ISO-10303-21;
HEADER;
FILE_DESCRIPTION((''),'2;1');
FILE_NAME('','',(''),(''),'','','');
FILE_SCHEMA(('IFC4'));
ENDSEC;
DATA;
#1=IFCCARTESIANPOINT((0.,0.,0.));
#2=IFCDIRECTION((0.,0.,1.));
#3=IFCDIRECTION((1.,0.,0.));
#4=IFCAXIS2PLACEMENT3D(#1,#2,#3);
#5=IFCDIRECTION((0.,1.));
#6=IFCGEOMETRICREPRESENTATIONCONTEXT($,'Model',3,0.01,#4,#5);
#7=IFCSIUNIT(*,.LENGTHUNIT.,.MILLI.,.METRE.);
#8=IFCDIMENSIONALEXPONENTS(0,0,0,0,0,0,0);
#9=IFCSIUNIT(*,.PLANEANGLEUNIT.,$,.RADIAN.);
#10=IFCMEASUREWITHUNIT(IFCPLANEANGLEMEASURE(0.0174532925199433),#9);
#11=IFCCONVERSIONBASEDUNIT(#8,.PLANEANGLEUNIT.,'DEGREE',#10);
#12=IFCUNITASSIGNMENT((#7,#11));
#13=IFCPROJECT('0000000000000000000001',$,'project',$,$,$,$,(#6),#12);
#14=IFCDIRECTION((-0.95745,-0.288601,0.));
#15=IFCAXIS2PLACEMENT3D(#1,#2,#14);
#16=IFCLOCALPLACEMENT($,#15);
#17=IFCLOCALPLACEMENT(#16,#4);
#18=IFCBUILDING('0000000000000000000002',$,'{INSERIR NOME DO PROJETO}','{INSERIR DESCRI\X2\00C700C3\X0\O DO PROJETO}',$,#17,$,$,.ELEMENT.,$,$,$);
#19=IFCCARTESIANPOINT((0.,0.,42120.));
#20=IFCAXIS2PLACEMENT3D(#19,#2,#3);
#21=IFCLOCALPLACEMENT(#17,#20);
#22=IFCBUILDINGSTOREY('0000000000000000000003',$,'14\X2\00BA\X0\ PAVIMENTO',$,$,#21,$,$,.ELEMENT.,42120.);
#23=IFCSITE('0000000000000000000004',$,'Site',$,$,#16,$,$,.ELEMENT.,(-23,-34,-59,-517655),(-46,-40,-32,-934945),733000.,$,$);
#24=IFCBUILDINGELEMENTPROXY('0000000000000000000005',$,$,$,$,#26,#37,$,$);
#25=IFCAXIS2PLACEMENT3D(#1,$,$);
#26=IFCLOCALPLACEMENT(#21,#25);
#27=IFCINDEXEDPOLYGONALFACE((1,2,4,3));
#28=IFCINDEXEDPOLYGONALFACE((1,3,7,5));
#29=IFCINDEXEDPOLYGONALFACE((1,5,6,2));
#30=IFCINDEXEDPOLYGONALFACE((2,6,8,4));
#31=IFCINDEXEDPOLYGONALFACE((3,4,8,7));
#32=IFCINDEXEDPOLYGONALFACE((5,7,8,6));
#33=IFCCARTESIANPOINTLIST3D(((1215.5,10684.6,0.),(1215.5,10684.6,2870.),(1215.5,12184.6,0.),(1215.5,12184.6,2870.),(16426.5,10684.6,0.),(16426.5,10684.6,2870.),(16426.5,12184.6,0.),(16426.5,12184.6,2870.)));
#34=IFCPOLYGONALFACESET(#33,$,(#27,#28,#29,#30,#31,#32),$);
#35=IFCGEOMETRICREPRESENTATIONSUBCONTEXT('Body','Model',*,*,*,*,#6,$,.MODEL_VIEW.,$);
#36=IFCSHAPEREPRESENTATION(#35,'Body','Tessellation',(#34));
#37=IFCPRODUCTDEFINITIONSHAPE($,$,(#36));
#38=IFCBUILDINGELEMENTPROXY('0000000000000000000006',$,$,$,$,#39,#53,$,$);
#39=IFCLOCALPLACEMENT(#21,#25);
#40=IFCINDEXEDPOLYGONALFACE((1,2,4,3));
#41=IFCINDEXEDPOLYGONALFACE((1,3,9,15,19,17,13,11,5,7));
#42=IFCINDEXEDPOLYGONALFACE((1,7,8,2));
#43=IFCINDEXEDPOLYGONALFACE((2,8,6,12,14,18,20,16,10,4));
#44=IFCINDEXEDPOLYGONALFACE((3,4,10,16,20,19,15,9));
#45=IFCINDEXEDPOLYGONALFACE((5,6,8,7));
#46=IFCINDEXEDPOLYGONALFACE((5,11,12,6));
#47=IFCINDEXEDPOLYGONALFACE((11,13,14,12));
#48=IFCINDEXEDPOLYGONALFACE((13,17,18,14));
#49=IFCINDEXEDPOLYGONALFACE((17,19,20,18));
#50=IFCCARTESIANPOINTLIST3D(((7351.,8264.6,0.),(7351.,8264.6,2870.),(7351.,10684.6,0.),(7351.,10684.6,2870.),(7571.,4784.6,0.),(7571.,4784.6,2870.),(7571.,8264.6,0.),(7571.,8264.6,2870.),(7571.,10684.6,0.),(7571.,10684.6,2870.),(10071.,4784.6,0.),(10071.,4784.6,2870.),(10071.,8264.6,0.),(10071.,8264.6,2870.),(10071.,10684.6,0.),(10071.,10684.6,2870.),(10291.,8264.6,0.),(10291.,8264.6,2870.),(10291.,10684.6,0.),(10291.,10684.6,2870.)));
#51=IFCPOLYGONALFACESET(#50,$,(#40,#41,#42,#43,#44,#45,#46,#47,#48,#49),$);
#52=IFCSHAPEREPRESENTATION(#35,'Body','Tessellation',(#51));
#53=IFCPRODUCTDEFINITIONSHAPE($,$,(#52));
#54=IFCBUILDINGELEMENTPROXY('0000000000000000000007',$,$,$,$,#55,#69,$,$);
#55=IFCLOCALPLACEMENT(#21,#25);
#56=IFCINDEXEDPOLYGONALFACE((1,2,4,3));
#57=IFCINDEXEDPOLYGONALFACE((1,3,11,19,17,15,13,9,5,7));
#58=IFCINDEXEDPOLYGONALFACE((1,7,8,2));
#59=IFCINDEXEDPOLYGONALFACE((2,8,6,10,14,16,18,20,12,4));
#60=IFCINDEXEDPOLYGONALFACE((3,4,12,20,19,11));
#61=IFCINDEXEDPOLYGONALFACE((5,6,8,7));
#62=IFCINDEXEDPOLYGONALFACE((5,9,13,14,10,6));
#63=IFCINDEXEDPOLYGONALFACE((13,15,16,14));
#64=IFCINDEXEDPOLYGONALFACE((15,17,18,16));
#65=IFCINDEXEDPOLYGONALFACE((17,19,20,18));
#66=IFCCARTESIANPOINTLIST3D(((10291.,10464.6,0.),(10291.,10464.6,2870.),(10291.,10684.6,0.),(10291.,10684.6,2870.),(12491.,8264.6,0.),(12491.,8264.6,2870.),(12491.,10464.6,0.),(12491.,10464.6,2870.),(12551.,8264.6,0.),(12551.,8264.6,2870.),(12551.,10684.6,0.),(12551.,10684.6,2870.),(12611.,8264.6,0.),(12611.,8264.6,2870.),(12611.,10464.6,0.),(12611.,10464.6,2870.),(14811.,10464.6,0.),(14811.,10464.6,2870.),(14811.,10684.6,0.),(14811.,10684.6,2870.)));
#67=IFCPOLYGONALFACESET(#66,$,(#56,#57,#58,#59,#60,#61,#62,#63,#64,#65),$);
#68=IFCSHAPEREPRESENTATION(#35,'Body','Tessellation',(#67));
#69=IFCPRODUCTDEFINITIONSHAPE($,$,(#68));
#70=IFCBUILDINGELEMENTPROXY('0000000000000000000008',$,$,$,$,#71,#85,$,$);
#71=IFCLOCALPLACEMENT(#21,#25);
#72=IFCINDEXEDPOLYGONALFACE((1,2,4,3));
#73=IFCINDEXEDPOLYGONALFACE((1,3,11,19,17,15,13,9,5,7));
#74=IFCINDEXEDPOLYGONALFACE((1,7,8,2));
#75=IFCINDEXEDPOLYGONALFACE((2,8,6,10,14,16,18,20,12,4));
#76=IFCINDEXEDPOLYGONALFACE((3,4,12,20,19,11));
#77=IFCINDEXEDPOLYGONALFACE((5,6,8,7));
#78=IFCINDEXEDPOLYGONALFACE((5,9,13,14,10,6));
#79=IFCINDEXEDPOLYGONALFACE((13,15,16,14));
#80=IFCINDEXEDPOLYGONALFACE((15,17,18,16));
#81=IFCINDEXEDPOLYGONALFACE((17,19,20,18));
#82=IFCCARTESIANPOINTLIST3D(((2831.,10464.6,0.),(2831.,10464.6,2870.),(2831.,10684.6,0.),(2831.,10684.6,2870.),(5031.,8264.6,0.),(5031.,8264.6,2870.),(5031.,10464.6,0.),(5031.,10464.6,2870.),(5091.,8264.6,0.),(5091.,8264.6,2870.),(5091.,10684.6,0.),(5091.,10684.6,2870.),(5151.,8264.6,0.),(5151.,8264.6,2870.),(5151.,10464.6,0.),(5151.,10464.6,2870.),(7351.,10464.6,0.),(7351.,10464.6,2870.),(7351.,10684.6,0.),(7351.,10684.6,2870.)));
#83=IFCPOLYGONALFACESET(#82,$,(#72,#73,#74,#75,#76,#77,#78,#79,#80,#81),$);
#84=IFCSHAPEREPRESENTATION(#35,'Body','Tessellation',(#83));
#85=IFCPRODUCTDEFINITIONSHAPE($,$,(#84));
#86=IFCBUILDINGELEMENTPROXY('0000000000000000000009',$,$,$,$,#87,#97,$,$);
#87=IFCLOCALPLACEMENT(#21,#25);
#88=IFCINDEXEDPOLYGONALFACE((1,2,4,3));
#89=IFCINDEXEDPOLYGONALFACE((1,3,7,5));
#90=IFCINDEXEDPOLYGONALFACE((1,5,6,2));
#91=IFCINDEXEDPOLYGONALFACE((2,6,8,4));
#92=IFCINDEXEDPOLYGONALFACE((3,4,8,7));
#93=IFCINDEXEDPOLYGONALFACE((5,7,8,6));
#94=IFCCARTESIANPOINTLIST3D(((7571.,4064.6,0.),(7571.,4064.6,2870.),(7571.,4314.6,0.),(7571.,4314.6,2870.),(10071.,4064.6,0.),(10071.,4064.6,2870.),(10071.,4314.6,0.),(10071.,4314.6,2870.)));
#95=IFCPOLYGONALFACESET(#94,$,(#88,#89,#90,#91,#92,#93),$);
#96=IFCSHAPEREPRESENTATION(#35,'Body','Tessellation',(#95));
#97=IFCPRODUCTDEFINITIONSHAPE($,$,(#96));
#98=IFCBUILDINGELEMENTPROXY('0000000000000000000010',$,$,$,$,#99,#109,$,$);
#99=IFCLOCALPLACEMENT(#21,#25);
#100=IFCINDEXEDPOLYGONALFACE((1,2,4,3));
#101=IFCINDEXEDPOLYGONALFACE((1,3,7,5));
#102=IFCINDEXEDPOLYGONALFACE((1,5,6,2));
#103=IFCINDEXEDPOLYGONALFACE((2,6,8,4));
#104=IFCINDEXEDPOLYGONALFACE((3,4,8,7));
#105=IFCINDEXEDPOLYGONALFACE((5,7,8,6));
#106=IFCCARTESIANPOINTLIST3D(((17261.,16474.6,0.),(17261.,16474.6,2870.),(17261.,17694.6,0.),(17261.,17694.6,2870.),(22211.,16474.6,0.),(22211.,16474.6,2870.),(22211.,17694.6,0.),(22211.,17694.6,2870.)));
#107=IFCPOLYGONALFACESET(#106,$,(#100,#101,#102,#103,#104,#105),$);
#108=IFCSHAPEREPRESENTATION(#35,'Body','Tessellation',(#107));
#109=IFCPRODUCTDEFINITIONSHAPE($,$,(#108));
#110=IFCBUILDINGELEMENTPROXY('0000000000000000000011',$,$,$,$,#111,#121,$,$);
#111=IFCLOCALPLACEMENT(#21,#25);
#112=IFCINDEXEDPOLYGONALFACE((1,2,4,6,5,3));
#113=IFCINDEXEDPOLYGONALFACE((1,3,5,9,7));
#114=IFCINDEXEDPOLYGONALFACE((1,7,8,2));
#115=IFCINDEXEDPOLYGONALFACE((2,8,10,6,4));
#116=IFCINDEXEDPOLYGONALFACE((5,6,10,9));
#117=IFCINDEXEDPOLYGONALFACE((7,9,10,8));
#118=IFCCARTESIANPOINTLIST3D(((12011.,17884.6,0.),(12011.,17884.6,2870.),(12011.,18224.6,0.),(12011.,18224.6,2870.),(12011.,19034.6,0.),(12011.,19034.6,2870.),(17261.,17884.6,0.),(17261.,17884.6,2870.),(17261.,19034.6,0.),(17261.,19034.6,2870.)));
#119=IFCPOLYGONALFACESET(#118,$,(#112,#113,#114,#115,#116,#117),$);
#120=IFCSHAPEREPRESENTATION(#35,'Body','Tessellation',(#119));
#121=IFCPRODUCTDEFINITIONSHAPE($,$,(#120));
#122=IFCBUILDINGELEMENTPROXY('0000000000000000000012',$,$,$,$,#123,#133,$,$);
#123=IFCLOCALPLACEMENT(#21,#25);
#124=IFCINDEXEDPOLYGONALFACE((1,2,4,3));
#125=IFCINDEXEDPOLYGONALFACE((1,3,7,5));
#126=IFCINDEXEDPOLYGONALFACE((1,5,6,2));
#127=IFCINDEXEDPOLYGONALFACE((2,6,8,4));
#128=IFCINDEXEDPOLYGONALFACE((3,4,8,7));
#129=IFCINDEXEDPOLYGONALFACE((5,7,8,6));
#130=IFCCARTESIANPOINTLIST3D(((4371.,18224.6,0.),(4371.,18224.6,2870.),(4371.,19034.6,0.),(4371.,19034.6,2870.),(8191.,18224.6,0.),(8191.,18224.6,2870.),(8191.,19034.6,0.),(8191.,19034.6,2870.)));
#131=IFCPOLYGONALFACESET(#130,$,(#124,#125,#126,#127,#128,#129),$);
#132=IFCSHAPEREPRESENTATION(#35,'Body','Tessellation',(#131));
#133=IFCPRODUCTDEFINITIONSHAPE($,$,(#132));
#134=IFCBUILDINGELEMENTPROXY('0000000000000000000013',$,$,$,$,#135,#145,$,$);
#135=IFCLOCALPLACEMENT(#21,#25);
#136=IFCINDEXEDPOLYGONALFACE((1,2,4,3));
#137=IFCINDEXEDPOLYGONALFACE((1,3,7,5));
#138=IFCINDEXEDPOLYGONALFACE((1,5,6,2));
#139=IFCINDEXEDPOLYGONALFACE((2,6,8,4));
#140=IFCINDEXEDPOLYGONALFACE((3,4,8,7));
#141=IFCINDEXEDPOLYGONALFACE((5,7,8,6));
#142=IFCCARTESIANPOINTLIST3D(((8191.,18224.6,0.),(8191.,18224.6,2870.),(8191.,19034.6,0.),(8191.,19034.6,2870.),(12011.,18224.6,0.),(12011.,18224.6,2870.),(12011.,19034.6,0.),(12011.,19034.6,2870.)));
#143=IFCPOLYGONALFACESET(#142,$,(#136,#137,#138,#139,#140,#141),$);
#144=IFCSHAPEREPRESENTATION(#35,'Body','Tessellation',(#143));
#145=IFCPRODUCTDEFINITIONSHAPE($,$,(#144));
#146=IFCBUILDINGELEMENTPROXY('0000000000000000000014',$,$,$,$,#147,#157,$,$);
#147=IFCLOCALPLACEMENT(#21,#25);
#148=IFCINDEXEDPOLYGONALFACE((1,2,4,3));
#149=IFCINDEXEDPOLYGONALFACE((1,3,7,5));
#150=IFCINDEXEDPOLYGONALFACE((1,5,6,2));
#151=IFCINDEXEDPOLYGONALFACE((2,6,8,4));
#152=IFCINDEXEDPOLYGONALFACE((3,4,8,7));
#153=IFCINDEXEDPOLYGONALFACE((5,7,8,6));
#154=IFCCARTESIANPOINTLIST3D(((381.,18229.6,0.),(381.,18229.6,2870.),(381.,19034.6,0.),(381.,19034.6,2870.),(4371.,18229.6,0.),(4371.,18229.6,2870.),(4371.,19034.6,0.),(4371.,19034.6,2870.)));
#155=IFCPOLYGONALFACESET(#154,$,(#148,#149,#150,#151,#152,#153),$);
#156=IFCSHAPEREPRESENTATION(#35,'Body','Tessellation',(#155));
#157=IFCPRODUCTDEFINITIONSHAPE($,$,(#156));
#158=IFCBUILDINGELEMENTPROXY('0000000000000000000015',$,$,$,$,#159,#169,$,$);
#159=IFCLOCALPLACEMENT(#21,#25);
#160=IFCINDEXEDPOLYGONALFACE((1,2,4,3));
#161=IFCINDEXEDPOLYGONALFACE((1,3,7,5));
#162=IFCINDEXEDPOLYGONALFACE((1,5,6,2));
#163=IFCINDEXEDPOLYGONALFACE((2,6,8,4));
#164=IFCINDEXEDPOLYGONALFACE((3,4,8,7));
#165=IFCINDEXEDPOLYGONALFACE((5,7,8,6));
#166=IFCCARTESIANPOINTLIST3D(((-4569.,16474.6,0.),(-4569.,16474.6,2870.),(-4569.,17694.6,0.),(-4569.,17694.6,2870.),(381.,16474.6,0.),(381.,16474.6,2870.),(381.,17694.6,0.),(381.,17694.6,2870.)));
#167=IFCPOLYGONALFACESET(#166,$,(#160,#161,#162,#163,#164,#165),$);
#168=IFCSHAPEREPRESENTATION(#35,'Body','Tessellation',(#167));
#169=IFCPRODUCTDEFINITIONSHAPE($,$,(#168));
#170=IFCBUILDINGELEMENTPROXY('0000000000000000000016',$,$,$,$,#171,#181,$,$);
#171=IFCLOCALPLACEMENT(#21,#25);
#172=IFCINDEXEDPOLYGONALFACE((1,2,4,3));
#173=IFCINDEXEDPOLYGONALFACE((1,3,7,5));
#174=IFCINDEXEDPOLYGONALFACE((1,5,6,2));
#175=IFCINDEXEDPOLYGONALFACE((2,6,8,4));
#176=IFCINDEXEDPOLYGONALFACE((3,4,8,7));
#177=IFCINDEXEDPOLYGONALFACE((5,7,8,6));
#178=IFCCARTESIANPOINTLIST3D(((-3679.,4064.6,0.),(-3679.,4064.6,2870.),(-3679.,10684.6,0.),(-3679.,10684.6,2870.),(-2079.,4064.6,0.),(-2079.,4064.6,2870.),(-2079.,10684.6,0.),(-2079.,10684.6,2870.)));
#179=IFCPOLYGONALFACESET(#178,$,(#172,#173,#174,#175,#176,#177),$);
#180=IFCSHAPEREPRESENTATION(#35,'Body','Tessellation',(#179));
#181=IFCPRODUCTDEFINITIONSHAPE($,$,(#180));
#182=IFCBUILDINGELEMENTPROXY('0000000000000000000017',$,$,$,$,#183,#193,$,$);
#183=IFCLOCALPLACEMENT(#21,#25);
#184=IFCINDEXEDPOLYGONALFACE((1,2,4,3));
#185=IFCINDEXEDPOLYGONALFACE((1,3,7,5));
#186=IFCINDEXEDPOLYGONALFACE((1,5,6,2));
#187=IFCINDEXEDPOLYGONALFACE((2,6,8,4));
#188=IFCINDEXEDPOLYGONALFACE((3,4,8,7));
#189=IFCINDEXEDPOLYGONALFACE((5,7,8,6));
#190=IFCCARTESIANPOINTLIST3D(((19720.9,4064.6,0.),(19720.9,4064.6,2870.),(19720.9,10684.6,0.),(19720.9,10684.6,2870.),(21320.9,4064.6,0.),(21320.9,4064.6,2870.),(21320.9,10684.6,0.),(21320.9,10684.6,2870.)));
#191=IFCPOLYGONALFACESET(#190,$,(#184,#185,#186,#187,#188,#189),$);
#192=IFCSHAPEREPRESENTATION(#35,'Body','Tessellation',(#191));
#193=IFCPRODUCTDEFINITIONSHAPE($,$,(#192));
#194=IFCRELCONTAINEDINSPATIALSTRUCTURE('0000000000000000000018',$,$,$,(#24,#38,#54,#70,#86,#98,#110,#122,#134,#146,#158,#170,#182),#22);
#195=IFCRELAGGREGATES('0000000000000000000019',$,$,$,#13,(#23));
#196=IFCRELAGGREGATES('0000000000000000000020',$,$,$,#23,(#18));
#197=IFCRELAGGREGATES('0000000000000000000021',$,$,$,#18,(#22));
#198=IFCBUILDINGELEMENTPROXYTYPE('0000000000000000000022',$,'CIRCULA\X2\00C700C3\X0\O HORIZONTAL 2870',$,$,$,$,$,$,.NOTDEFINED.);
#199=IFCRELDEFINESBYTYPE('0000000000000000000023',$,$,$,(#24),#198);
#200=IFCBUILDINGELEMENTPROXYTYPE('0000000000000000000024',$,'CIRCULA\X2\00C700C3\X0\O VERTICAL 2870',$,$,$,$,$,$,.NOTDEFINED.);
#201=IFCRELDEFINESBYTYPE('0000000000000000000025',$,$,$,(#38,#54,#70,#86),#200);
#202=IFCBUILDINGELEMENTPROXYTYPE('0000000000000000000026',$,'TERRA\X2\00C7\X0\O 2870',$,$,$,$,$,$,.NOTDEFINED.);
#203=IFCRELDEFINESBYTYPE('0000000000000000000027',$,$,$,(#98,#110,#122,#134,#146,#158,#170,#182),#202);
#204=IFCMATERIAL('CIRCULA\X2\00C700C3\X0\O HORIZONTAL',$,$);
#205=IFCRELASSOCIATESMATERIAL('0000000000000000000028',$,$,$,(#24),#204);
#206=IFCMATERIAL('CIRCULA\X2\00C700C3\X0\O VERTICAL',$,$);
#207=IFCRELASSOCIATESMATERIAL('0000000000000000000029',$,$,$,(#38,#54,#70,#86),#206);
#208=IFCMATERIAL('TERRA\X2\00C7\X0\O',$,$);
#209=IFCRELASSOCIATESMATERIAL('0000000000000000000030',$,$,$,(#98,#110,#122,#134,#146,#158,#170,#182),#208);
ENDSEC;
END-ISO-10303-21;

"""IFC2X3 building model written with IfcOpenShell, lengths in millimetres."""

from ifc_helpers import new_model, entity, si_unit, converted_unit, direction, frame, origin_with_axes, place, context, subcontext, project, spatial, polyline, outline, extrude, material, type_object, element, save


model = new_model("IFC2X3")

# Units and contexts
model_context = context("Model", 3, precision=0.01, world=origin_with_axes(), true_north=direction((0.0, 1.0)))
body_context = subcontext(model_context, "Body", "Model", "MODEL_VIEW")
ifc_project = project(units=[si_unit("LENGTHUNIT", "METRE", prefix="MILLI"), converted_unit("PLANEANGLEUNIT", "DEGREE", entity("IfcPlaneAngleMeasure", 0.0174532925199433), si_unit("PLANEANGLEUNIT", "RADIAN"), dimensions=[0, 0, 0, 0, 0, 0, 0])], contexts=[model_context])

# Site, building, storey
site_placement = place(None, frame((0.0, 0.0, 0.0), z_axis=(0.0, 0.0, 1.0), x_axis=(-0.95745, -0.288601, 0.0)))
site = spatial("IfcSite", under=ifc_project, at=site_placement, Name="Site", CompositionType="ELEMENT", RefLatitude=(-23, -34, -59, -517655), RefLongitude=(-46, -40, -32, -934945), RefElevation=733000.0)
building_placement = place(site_placement, origin_with_axes())
building = spatial("IfcBuilding", under=site, at=building_placement, Name="{INSERIR NOME DO PROJETO}", Description="{INSERIR DESCRIÇÃO DO PROJETO}", CompositionType="ELEMENT")
storey_placement = place(building_placement, frame((0.0, 0.0, 42120.0), z_axis=(0.0, 0.0, 1.0), x_axis=(1.0, 0.0, 0.0)))
storey = spatial("IfcBuildingStorey", under=building, at=storey_placement, Name="14º PAVIMENTO", CompositionType="ELEMENT", Elevation=42120.0)

# Building element proxies
ifc_material_1 = material(Name="CIRCULAÇÃO HORIZONTAL")
building_element_proxy_type_1 = type_object("IfcBuildingElementProxyType", Name="CIRCULAÇÃO HORIZONTAL 2870", PredefinedType="NOTDEFINED")
proxy_1_placement = place(storey_placement, frame((1215.5, 10684.6, 0.0), z_axis=(0.0, 0.0, 1.0), x_axis=(1.0, 0.0, 0.0)))
element("IfcBuildingElementProxy", 1, at=proxy_1_placement, inside=storey, type_object=building_element_proxy_type_1, material=ifc_material_1, context=body_context, shape_type="SweptSolid", body=[
    extrude(outline(polyline([(0.0, 0.0), (15211.0, 0.0), (15211.0, 1500.0), (0.0, 1500.0), (0.0, 0.0)])), origin_with_axes(), (0.0, 0.0, 1.0), 2870.0),
])
ifc_material_2 = material(Name="CIRCULAÇÃO VERTICAL")
building_element_proxy_type_2 = type_object("IfcBuildingElementProxyType", Name="CIRCULAÇÃO VERTICAL 2870", PredefinedType="NOTDEFINED")
proxy_2_placement = place(storey_placement, frame((7351.0, 10684.6, 0.0), z_axis=(0.0, 0.0, 1.0), x_axis=(1.0, 0.0, 0.0)))
element("IfcBuildingElementProxy", 2, at=proxy_2_placement, inside=storey, type_object=building_element_proxy_type_2, material=ifc_material_2, context=body_context, shape_type="SweptSolid", body=[
    extrude(outline(polyline([(0.0, 0.0), (0.0, -2420.0), (220.0, -2420.0), (220.0, -5900.0), (2720.0, -5900.0), (2720.0, -2420.0), (2940.0, -2420.0), (2940.0, 0.0), (2720.0, 0.0), (220.0, 0.0), (0.0, 0.0)])), origin_with_axes(), (0.0, 0.0, 1.0), 2870.0),
])
proxy_3_placement = place(storey_placement, frame((10291.0, 10684.6, 0.0), z_axis=(0.0, 0.0, 1.0), x_axis=(1.0, 0.0, 0.0)))
element("IfcBuildingElementProxy", 3, at=proxy_3_placement, inside=storey, type_object=building_element_proxy_type_2, material=ifc_material_2, context=body_context, shape_type="SweptSolid", body=[
    extrude(outline(polyline([(0.0, 0.0), (0.0, -220.0), (2200.0, -220.0), (2200.0, -2420.0), (2260.0, -2420.0), (2320.0, -2420.0), (2320.0, -220.0), (4520.0, -220.0), (4520.0, 0.0), (2260.0, 0.0), (0.0, 0.0)])), origin_with_axes(), (0.0, 0.0, 1.0), 2870.0),
])
proxy_4_placement = place(storey_placement, frame((5091.0, 10684.6, 0.0), z_axis=(0.0, 0.0, 1.0), x_axis=(1.0, 0.0, 0.0)))
element("IfcBuildingElementProxy", 4, at=proxy_4_placement, inside=storey, type_object=building_element_proxy_type_2, material=ifc_material_2, context=body_context, shape_type="SweptSolid", body=[
    extrude(outline(polyline([(0.0, 0.0), (-2260.0, 0.0), (-2260.0, -220.0), (-60.0, -220.0), (-60.0, -2420.0), (0.0, -2420.0), (60.0, -2420.0), (60.0, -220.0), (2260.0, -220.0), (2260.0, 0.0), (0.0, 0.0)])), origin_with_axes(), (0.0, 0.0, 1.0), 2870.0),
])
proxy_5_placement = place(storey_placement, frame((7571.0, 4064.6, 0.0), z_axis=(0.0, 0.0, 1.0), x_axis=(1.0, 0.0, 0.0)))
element("IfcBuildingElementProxy", 5, at=proxy_5_placement, inside=storey, type_object=building_element_proxy_type_2, material=ifc_material_2, context=body_context, shape_type="SweptSolid", body=[
    extrude(outline(polyline([(0.0, 0.0), (2500.0, 0.0), (2500.0, 250.0), (0.0, 250.0), (0.0, 0.0)])), origin_with_axes(), (0.0, 0.0, 1.0), 2870.0),
])
ifc_material_3 = material(Name="TERRAÇO")
building_element_proxy_type_3 = type_object("IfcBuildingElementProxyType", Name="TERRAÇO 2870", PredefinedType="NOTDEFINED")
proxy_6_placement = place(storey_placement, frame((17261.0, 16474.6, 0.0), z_axis=(0.0, 0.0, 1.0), x_axis=(1.0, 0.0, 0.0)))
element("IfcBuildingElementProxy", 6, at=proxy_6_placement, inside=storey, type_object=building_element_proxy_type_3, material=ifc_material_3, context=body_context, shape_type="SweptSolid", body=[
    extrude(outline(polyline([(0.0, 0.0), (4950.0, 0.0), (4950.0, 1220.0), (0.0, 1220.0), (0.0, 0.0)])), origin_with_axes(), (0.0, 0.0, 1.0), 2870.0),
])
proxy_7_placement = place(storey_placement, frame((12011.0, 19034.6, 0.0), z_axis=(0.0, 0.0, 1.0), x_axis=(1.0, 0.0, 0.0)))
element("IfcBuildingElementProxy", 7, at=proxy_7_placement, inside=storey, type_object=building_element_proxy_type_3, material=ifc_material_3, context=body_context, shape_type="SweptSolid", body=[
    extrude(outline(polyline([(0.0, 0.0), (0.0, -810.0), (0.0, -1150.0), (5250.0, -1150.0), (5250.0, 0.0), (0.0, 0.0)])), origin_with_axes(), (0.0, 0.0, 1.0), 2870.0),
])
for number, where, z_axis, x_axis in (
    (8, (4371.0, 18224.6, 0.0), (0.0, 0.0, 1.0), (1.0, 0.0, 0.0)),
    (9, (8191.0, 18224.6, 0.0), (0.0, 0.0, 1.0), (1.0, 0.0, 0.0)),
):
    element("IfcBuildingElementProxy", number, at=place(storey_placement, frame(where, z_axis=z_axis, x_axis=x_axis)), inside=storey, type_object=building_element_proxy_type_3, material=ifc_material_3, context=body_context, shape_type="SweptSolid", body=[
        extrude(outline(polyline([(0.0, 0.0), (3820.0, 0.0), (3820.0, 810.0), (0.0, 810.0), (0.0, 0.0)])), origin_with_axes(), (0.0, 0.0, 1.0), 2870.0),
    ])
proxy_8_placement = place(storey_placement, frame((381.0, 19034.6, 0.0), z_axis=(0.0, 0.0, 1.0), x_axis=(1.0, 0.0, 0.0)))
element("IfcBuildingElementProxy", 10, at=proxy_8_placement, inside=storey, type_object=building_element_proxy_type_3, material=ifc_material_3, context=body_context, shape_type="SweptSolid", body=[
    extrude(outline(polyline([(0.0, 0.0), (0.0, -805.0), (3990.0, -805.0), (3990.0, 0.0), (0.0, 0.0)])), origin_with_axes(), (0.0, 0.0, 1.0), 2870.0),
])
proxy_9_placement = place(storey_placement, frame((381.0, 17694.6, 0.0), z_axis=(0.0, 0.0, 1.0), x_axis=(1.0, 0.0, 0.0)))
element("IfcBuildingElementProxy", 11, at=proxy_9_placement, inside=storey, type_object=building_element_proxy_type_3, material=ifc_material_3, context=body_context, shape_type="SweptSolid", body=[
    extrude(outline(polyline([(0.0, 0.0), (-4950.0, 0.0), (-4950.0, -1220.0), (0.0, -1220.0), (0.0, 0.0)])), origin_with_axes(), (0.0, 0.0, 1.0), 2870.0),
])
proxy_10_placement = place(storey_placement, frame((-3679.0, 4064.6, 0.0), z_axis=(0.0, 0.0, 1.0), x_axis=(1.0, 0.0, 0.0)))
element("IfcBuildingElementProxy", 12, at=proxy_10_placement, inside=storey, type_object=building_element_proxy_type_3, material=ifc_material_3, context=body_context, shape_type="SweptSolid", body=[
    extrude(outline(polyline([(0.0, 0.0), (1600.0, 0.0), (1600.0, 6620.0), (0.0, 6620.0), (0.0, 0.0)])), origin_with_axes(), (0.0, 0.0, 1.0), 2870.0),
])
proxy_11_placement = place(storey_placement, frame((21320.9, 4064.6, 0.0), z_axis=(0.0, 0.0, 1.0), x_axis=(1.0, 0.0, 0.0)))
element("IfcBuildingElementProxy", 13, at=proxy_11_placement, inside=storey, type_object=building_element_proxy_type_3, material=ifc_material_3, context=body_context, shape_type="SweptSolid", body=[
    extrude(outline(polyline([(0.0, 0.0), (0.0, 6620.0), (-1600.0, 6620.0), (-1600.0, 0.0), (0.0, 0.0)])), origin_with_axes(), (0.0, 0.0, 1.0), 2870.0),
])

save(model, "model.ifc")
